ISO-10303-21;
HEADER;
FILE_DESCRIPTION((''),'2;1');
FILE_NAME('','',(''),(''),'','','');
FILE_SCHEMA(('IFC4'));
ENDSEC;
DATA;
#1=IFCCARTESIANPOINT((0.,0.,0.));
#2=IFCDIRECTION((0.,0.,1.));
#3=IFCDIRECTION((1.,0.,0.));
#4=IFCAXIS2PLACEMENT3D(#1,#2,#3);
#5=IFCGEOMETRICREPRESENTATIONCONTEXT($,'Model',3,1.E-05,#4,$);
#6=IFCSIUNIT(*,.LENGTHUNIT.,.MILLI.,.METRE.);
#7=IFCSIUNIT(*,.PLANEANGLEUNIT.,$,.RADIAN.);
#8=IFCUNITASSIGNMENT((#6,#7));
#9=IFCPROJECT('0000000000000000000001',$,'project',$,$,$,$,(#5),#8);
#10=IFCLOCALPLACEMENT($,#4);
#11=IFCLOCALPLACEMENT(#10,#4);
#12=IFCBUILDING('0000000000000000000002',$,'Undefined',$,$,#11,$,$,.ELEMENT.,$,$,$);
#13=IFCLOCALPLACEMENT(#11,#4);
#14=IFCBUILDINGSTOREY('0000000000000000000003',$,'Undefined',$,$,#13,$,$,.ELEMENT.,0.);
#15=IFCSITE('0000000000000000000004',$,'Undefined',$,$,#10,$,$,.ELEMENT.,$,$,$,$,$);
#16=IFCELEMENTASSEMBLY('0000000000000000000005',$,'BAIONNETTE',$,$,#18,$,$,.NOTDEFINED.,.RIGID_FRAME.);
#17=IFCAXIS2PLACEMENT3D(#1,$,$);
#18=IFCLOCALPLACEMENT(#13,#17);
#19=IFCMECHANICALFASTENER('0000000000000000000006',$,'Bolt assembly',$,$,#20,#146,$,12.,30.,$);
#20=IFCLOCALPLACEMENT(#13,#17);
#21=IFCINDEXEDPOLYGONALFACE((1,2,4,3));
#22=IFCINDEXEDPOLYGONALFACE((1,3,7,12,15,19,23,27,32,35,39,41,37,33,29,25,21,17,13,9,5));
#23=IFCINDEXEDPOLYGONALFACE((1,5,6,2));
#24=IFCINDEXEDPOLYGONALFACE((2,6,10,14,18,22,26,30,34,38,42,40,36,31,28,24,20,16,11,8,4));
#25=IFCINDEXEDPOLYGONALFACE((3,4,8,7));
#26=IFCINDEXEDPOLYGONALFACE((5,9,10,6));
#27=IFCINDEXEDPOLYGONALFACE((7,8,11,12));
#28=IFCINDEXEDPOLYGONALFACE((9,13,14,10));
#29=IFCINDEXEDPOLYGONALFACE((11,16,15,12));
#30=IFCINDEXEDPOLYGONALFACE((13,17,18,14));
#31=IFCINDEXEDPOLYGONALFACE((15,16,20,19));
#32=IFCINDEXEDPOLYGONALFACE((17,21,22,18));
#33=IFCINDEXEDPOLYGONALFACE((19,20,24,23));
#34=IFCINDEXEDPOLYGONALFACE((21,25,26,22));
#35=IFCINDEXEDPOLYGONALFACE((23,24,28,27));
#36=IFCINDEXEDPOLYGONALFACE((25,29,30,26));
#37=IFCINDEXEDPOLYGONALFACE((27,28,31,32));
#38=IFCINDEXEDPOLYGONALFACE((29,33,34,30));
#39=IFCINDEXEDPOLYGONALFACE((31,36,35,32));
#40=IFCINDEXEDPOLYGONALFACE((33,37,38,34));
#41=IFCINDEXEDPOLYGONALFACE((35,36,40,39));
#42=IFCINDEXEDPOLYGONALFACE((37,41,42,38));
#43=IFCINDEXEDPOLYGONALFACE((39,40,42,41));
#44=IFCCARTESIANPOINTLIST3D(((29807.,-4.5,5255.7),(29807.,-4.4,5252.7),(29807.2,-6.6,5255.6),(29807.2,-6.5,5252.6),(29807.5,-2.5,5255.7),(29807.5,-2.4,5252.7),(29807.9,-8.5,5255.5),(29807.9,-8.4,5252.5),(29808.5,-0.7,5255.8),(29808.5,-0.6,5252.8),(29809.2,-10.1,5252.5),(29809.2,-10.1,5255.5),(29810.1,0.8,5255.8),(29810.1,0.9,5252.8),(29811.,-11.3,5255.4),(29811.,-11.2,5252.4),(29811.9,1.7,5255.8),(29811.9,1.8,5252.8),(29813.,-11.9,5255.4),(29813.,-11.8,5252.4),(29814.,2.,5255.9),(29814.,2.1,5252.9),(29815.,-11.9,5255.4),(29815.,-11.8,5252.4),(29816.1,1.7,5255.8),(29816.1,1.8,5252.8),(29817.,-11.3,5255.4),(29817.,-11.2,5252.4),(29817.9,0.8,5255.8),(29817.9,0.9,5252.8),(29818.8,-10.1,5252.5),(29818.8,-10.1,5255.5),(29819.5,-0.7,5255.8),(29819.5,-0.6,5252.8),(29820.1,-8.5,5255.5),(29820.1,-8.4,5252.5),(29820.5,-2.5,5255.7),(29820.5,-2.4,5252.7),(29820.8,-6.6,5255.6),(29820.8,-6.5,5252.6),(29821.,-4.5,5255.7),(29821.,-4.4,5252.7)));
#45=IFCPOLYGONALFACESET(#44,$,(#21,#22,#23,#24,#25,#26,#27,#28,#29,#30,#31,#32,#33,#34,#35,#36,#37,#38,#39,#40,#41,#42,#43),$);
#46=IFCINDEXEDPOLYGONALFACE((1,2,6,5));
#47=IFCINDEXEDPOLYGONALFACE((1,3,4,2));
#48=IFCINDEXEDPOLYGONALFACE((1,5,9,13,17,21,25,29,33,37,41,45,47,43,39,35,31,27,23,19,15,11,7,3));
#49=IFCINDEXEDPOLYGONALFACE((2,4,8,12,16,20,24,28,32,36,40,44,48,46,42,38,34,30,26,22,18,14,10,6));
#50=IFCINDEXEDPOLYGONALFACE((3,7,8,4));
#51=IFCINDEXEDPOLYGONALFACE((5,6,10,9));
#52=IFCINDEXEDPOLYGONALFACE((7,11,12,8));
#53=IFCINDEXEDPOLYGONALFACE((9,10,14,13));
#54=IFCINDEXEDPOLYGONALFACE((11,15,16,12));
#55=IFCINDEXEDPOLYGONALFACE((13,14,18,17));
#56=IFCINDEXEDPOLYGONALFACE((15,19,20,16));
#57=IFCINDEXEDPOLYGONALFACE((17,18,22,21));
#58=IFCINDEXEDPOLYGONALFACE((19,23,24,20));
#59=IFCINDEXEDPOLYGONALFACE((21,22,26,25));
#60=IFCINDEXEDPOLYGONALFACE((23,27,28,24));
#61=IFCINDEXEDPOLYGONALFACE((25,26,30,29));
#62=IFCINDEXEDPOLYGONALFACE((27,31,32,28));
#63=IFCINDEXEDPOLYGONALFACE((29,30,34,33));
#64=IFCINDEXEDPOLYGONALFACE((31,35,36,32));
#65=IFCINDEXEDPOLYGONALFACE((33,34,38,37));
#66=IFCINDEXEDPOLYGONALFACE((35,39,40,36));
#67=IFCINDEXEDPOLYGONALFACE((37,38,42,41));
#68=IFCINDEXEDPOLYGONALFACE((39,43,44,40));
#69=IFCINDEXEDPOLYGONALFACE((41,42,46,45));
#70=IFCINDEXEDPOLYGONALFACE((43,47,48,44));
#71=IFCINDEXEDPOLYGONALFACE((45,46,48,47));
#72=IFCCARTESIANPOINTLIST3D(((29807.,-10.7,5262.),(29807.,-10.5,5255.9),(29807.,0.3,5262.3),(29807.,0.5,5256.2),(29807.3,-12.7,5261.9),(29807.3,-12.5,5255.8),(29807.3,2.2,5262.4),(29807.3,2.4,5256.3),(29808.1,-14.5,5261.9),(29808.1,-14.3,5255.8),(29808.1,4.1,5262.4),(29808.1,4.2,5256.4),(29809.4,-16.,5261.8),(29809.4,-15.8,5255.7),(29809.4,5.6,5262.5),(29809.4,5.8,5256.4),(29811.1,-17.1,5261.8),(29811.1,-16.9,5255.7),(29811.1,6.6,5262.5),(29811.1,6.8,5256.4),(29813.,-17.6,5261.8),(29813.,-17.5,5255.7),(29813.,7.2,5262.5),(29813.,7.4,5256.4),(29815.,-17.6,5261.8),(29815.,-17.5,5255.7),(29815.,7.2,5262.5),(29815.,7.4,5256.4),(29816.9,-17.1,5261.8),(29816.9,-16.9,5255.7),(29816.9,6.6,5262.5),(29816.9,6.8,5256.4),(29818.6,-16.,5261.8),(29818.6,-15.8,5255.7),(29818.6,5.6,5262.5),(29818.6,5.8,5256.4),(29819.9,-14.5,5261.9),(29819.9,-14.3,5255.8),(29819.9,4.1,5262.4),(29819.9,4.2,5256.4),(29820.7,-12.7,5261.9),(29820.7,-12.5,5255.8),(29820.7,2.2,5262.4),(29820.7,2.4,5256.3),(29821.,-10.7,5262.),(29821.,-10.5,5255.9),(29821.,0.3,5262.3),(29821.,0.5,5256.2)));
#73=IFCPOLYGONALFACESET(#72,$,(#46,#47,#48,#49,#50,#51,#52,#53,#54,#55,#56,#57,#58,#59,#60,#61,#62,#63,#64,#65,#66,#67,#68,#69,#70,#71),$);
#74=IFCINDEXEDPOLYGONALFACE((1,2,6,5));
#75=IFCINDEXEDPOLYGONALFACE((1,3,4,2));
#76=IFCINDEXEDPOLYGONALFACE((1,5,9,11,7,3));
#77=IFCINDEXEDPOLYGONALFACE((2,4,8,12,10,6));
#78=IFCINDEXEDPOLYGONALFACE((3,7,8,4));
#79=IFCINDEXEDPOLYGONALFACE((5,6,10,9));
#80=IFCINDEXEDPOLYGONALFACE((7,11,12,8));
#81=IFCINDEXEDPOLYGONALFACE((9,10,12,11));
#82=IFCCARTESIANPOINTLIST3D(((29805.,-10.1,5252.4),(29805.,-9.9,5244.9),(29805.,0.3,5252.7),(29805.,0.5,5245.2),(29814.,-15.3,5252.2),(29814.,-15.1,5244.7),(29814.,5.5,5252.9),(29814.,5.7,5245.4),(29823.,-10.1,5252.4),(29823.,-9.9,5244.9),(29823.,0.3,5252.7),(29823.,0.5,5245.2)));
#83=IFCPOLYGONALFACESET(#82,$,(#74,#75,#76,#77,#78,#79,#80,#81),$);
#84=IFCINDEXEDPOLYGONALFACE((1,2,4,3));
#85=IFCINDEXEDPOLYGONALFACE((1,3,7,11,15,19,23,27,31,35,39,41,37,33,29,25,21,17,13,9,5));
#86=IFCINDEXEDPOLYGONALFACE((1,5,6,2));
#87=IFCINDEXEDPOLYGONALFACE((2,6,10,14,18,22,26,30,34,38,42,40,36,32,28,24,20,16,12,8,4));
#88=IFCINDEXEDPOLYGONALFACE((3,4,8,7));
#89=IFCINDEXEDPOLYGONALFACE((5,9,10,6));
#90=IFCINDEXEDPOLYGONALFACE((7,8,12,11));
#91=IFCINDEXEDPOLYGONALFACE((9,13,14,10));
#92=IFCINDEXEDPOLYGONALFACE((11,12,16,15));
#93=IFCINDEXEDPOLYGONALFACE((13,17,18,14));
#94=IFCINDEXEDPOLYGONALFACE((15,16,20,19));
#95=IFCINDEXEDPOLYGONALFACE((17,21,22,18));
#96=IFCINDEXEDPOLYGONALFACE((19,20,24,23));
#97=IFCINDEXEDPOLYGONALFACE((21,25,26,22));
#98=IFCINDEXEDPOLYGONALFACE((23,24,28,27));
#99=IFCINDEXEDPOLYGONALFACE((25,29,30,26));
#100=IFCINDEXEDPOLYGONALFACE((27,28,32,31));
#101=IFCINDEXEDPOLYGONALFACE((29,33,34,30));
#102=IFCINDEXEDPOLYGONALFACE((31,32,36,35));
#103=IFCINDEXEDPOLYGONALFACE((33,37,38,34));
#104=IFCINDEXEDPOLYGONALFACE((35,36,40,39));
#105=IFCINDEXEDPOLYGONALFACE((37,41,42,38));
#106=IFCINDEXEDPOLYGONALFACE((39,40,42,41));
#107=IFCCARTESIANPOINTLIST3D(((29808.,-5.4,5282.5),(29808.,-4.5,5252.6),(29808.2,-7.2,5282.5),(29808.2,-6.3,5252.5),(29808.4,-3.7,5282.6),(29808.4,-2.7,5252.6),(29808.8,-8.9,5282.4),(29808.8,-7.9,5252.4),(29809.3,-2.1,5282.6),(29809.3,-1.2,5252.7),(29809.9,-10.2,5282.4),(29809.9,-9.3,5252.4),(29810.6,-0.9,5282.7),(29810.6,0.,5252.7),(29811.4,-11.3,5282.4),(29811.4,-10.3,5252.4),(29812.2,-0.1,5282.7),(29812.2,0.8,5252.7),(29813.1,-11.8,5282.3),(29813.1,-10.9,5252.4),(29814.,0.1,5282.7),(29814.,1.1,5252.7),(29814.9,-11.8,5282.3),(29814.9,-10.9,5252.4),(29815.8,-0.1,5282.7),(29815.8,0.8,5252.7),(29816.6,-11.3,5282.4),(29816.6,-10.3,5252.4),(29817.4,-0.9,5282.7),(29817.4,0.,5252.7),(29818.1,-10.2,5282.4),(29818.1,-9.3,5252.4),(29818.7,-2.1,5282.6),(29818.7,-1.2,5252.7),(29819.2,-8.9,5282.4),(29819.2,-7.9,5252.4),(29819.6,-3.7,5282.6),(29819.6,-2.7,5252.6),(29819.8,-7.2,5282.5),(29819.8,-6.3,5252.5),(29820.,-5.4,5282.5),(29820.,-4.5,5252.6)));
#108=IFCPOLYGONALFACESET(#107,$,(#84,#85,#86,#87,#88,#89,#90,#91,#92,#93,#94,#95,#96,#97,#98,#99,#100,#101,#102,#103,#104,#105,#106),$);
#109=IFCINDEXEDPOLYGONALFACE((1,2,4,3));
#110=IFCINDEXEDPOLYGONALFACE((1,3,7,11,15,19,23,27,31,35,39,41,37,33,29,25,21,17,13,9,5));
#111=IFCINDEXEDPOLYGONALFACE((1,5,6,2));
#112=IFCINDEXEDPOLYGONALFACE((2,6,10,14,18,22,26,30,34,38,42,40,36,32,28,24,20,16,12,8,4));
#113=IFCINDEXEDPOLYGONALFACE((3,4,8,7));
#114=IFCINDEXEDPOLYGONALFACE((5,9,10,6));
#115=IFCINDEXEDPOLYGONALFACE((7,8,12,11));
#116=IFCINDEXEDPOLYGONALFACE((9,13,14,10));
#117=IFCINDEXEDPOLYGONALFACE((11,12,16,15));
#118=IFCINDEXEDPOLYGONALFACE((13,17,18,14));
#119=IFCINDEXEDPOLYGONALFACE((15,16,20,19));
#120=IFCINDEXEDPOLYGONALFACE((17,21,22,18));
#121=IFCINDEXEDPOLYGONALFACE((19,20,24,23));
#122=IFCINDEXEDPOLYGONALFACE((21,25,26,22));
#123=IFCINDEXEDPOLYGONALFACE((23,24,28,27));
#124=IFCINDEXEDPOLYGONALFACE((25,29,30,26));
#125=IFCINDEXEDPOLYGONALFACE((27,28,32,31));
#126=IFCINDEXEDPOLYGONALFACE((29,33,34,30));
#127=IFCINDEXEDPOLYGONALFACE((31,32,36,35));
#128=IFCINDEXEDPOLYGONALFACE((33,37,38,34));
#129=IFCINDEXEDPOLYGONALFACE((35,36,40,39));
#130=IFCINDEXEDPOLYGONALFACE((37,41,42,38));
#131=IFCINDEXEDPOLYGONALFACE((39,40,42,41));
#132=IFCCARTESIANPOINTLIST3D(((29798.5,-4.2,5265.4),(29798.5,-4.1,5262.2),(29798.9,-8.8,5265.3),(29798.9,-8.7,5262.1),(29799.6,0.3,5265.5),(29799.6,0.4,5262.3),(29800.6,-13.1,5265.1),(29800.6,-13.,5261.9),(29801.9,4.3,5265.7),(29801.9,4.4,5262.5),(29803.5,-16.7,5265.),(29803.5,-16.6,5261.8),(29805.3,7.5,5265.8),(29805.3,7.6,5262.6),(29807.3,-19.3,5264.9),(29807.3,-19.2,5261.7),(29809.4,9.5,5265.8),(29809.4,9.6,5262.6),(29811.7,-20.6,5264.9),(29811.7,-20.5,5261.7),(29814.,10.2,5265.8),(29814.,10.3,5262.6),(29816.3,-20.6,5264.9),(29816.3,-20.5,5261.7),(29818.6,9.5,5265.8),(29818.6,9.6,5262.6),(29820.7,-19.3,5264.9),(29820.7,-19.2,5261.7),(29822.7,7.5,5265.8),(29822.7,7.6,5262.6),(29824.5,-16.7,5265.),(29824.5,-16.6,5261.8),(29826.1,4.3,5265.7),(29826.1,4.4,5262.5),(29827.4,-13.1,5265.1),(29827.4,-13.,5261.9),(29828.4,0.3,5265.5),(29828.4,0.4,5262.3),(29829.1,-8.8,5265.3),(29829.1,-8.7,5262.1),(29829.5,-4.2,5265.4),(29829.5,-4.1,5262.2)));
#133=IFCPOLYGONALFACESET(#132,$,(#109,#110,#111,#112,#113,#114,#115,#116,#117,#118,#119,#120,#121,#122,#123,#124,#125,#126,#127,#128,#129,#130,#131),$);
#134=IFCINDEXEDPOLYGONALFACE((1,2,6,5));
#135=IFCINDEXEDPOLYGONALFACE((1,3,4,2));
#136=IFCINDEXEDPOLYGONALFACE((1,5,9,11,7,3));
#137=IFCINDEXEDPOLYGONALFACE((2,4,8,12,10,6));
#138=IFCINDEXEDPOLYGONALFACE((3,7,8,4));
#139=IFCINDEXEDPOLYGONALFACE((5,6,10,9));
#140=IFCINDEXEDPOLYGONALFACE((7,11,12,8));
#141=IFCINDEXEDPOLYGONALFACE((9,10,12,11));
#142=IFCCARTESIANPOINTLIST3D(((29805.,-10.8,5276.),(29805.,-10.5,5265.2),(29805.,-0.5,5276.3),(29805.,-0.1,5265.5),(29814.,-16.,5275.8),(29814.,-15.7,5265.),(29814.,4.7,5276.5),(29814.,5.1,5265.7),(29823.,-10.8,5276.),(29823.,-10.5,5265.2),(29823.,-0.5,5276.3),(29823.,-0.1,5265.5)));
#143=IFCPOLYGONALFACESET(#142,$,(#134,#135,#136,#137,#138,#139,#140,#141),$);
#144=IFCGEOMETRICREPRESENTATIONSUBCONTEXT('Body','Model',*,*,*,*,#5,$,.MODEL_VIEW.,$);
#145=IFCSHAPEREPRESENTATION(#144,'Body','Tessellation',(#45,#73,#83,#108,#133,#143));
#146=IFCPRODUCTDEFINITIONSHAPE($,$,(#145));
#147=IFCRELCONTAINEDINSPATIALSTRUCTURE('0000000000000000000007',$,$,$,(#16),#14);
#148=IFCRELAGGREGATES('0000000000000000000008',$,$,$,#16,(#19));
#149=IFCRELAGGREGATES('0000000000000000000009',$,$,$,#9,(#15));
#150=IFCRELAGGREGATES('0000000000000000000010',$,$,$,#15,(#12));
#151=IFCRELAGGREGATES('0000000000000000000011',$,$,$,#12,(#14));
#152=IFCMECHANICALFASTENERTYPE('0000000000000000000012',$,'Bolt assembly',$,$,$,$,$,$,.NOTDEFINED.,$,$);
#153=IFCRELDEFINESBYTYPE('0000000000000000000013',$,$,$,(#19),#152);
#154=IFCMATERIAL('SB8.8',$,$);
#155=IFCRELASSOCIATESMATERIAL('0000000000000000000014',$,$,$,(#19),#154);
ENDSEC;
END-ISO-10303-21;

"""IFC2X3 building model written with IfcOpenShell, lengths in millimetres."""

from ifc_helpers import new_model, si_unit, frame, frame_2d, origin_with_axes, origin_2d_with_axis, place, context, subcontext, project, spatial, polyline, circle_curve, parameter, trimmed, segment, composite_curve, circle, outline, extrude, source, transform, mapped, material, type_object, element, aggregate, save


model = new_model("IFC2X3")

# Units and contexts
model_context = context("Model", 3, precision=1e-05, world=origin_with_axes())
body_context = subcontext(model_context, "Body", "Model", "MODEL_VIEW")
ifc_project = project(units=[si_unit("LENGTHUNIT", "METRE", prefix="MILLI"), si_unit("PLANEANGLEUNIT", "RADIAN")], contexts=[model_context])

# Site, building, storey
site_placement = place(None, origin_with_axes())
site = spatial("IfcSite", under=ifc_project, at=site_placement, Name="Undefined", CompositionType="ELEMENT")
building_placement = place(site_placement, origin_with_axes())
building = spatial("IfcBuilding", under=site, at=building_placement, Name="Undefined", CompositionType="ELEMENT")
storey_placement = place(building_placement, origin_with_axes())
storey = spatial("IfcBuildingStorey", under=building, at=storey_placement, Name="Undefined", CompositionType="ELEMENT", Elevation=0.0)

# Element assembly
assembly_1_placement = place(storey_placement, origin_with_axes())
assembly_1 = element("IfcElementAssembly", 1, at=assembly_1_placement, inside=storey, Name="BAIONNETTE", AssemblyPlace="NOTDEFINED", PredefinedType="RIGID_FRAME")

# Mechanical fastener
ifc_material_1 = material(Name="SB8.8")
mechanical_fastener_type = type_object("IfcMechanicalFastenerType", Name="Bolt assembly")
shared_shape_1 = source(origin_with_axes(), body_context, "Body", "SweptSolid", [
    extrude(circle(Radius=7.0, at=origin_2d_with_axis()), frame((0.0, -2.9, 0.0), z_axis=(0.0, 1.0, 0.0), x_axis=(1.0, 0.0, 0.0)), (0.0, 0.0, 1.0), 3.0),
    extrude(outline(composite_curve([segment(polyline([(-5.5, 7.0), (5.5, 7.0)]), True, "CONTINUOUS"), segment(trimmed(circle_curve(frame_2d((5.5, 0.0), x_axis=(0.0, 1.0)), 7.0), [parameter(0.0)], [parameter(3.141593)], False, "PARAMETER"), True, "CONTINUOUS"), segment(polyline([(5.5, -7.0), (-5.5, -7.0)]), True, "CONTINUOUS"), segment(trimmed(circle_curve(frame_2d((-5.5, 0.0), x_axis=(0.0, -1.0)), 7.0), [parameter(0.0)], [parameter(3.141593)], False, "PARAMETER"), True, "DISCONTINUOUS")], self_intersect=False)), frame((0.0, 0.5, 0.0), z_axis=(0.0, 1.0, 0.0), x_axis=(1.0, 0.0, 0.0)), (0.0, 0.0, 1.0), 6.1),
    extrude(outline(polyline([(10.4, 0.0), (5.2, 9.0), (-5.2, 9.0), (-10.4, 0.0), (-5.2, -9.0), (5.2, -9.0), (10.4, 0.0)])), frame((0.0, -10.5, 0.0), z_axis=(0.0, 1.0, 0.0), x_axis=(1.0, 0.0, 0.0)), (0.0, 0.0, 1.0), 7.5),
    extrude(circle(Radius=6.0, at=origin_2d_with_axis()), frame((0.0, -3.0, 0.0), z_axis=(0.0, 1.0, 0.0), x_axis=(1.0, 0.0, 0.0)), (0.0, 0.0, 1.0), 30.0),
    extrude(circle(Radius=15.5, at=origin_2d_with_axis()), frame((0.0, 6.6, 0.0), z_axis=(0.0, 1.0, 0.0), x_axis=(1.0, 0.0, 0.0)), (0.0, 0.0, 1.0), 3.2),
    extrude(outline(polyline([(10.4, 0.0), (5.2, 9.0), (-5.2, 9.0), (-10.4, 0.0), (-5.2, -9.0), (5.2, -9.0), (10.4, 0.0)])), frame((0.0, 9.8, 0.0), z_axis=(0.0, 1.0, 0.0), x_axis=(1.0, 0.0, 0.0)), (0.0, 0.0, 1.0), 10.8),
])
mechanical_fastener_1_placement = place(assembly_1_placement, frame((29814.0, -5.0, 5255.5), z_axis=(1.0, 0.0, 0.0), x_axis=(0.0, 0.99952, 0.030985)))
mechanical_fastener_1 = element("IfcMechanicalFastener", 2, at=mechanical_fastener_1_placement, type_object=mechanical_fastener_type, material=ifc_material_1, Name="Bolt assembly", NominalDiameter=12.0, NominalLength=30.0, context=body_context, shape_type="MappedRepresentation", body=[
    mapped(shared_shape_1, transform((0.0, 0.0, 0.0))),
])

aggregate(assembly_1, [mechanical_fastener_1])

save(model, "model.ifc")
